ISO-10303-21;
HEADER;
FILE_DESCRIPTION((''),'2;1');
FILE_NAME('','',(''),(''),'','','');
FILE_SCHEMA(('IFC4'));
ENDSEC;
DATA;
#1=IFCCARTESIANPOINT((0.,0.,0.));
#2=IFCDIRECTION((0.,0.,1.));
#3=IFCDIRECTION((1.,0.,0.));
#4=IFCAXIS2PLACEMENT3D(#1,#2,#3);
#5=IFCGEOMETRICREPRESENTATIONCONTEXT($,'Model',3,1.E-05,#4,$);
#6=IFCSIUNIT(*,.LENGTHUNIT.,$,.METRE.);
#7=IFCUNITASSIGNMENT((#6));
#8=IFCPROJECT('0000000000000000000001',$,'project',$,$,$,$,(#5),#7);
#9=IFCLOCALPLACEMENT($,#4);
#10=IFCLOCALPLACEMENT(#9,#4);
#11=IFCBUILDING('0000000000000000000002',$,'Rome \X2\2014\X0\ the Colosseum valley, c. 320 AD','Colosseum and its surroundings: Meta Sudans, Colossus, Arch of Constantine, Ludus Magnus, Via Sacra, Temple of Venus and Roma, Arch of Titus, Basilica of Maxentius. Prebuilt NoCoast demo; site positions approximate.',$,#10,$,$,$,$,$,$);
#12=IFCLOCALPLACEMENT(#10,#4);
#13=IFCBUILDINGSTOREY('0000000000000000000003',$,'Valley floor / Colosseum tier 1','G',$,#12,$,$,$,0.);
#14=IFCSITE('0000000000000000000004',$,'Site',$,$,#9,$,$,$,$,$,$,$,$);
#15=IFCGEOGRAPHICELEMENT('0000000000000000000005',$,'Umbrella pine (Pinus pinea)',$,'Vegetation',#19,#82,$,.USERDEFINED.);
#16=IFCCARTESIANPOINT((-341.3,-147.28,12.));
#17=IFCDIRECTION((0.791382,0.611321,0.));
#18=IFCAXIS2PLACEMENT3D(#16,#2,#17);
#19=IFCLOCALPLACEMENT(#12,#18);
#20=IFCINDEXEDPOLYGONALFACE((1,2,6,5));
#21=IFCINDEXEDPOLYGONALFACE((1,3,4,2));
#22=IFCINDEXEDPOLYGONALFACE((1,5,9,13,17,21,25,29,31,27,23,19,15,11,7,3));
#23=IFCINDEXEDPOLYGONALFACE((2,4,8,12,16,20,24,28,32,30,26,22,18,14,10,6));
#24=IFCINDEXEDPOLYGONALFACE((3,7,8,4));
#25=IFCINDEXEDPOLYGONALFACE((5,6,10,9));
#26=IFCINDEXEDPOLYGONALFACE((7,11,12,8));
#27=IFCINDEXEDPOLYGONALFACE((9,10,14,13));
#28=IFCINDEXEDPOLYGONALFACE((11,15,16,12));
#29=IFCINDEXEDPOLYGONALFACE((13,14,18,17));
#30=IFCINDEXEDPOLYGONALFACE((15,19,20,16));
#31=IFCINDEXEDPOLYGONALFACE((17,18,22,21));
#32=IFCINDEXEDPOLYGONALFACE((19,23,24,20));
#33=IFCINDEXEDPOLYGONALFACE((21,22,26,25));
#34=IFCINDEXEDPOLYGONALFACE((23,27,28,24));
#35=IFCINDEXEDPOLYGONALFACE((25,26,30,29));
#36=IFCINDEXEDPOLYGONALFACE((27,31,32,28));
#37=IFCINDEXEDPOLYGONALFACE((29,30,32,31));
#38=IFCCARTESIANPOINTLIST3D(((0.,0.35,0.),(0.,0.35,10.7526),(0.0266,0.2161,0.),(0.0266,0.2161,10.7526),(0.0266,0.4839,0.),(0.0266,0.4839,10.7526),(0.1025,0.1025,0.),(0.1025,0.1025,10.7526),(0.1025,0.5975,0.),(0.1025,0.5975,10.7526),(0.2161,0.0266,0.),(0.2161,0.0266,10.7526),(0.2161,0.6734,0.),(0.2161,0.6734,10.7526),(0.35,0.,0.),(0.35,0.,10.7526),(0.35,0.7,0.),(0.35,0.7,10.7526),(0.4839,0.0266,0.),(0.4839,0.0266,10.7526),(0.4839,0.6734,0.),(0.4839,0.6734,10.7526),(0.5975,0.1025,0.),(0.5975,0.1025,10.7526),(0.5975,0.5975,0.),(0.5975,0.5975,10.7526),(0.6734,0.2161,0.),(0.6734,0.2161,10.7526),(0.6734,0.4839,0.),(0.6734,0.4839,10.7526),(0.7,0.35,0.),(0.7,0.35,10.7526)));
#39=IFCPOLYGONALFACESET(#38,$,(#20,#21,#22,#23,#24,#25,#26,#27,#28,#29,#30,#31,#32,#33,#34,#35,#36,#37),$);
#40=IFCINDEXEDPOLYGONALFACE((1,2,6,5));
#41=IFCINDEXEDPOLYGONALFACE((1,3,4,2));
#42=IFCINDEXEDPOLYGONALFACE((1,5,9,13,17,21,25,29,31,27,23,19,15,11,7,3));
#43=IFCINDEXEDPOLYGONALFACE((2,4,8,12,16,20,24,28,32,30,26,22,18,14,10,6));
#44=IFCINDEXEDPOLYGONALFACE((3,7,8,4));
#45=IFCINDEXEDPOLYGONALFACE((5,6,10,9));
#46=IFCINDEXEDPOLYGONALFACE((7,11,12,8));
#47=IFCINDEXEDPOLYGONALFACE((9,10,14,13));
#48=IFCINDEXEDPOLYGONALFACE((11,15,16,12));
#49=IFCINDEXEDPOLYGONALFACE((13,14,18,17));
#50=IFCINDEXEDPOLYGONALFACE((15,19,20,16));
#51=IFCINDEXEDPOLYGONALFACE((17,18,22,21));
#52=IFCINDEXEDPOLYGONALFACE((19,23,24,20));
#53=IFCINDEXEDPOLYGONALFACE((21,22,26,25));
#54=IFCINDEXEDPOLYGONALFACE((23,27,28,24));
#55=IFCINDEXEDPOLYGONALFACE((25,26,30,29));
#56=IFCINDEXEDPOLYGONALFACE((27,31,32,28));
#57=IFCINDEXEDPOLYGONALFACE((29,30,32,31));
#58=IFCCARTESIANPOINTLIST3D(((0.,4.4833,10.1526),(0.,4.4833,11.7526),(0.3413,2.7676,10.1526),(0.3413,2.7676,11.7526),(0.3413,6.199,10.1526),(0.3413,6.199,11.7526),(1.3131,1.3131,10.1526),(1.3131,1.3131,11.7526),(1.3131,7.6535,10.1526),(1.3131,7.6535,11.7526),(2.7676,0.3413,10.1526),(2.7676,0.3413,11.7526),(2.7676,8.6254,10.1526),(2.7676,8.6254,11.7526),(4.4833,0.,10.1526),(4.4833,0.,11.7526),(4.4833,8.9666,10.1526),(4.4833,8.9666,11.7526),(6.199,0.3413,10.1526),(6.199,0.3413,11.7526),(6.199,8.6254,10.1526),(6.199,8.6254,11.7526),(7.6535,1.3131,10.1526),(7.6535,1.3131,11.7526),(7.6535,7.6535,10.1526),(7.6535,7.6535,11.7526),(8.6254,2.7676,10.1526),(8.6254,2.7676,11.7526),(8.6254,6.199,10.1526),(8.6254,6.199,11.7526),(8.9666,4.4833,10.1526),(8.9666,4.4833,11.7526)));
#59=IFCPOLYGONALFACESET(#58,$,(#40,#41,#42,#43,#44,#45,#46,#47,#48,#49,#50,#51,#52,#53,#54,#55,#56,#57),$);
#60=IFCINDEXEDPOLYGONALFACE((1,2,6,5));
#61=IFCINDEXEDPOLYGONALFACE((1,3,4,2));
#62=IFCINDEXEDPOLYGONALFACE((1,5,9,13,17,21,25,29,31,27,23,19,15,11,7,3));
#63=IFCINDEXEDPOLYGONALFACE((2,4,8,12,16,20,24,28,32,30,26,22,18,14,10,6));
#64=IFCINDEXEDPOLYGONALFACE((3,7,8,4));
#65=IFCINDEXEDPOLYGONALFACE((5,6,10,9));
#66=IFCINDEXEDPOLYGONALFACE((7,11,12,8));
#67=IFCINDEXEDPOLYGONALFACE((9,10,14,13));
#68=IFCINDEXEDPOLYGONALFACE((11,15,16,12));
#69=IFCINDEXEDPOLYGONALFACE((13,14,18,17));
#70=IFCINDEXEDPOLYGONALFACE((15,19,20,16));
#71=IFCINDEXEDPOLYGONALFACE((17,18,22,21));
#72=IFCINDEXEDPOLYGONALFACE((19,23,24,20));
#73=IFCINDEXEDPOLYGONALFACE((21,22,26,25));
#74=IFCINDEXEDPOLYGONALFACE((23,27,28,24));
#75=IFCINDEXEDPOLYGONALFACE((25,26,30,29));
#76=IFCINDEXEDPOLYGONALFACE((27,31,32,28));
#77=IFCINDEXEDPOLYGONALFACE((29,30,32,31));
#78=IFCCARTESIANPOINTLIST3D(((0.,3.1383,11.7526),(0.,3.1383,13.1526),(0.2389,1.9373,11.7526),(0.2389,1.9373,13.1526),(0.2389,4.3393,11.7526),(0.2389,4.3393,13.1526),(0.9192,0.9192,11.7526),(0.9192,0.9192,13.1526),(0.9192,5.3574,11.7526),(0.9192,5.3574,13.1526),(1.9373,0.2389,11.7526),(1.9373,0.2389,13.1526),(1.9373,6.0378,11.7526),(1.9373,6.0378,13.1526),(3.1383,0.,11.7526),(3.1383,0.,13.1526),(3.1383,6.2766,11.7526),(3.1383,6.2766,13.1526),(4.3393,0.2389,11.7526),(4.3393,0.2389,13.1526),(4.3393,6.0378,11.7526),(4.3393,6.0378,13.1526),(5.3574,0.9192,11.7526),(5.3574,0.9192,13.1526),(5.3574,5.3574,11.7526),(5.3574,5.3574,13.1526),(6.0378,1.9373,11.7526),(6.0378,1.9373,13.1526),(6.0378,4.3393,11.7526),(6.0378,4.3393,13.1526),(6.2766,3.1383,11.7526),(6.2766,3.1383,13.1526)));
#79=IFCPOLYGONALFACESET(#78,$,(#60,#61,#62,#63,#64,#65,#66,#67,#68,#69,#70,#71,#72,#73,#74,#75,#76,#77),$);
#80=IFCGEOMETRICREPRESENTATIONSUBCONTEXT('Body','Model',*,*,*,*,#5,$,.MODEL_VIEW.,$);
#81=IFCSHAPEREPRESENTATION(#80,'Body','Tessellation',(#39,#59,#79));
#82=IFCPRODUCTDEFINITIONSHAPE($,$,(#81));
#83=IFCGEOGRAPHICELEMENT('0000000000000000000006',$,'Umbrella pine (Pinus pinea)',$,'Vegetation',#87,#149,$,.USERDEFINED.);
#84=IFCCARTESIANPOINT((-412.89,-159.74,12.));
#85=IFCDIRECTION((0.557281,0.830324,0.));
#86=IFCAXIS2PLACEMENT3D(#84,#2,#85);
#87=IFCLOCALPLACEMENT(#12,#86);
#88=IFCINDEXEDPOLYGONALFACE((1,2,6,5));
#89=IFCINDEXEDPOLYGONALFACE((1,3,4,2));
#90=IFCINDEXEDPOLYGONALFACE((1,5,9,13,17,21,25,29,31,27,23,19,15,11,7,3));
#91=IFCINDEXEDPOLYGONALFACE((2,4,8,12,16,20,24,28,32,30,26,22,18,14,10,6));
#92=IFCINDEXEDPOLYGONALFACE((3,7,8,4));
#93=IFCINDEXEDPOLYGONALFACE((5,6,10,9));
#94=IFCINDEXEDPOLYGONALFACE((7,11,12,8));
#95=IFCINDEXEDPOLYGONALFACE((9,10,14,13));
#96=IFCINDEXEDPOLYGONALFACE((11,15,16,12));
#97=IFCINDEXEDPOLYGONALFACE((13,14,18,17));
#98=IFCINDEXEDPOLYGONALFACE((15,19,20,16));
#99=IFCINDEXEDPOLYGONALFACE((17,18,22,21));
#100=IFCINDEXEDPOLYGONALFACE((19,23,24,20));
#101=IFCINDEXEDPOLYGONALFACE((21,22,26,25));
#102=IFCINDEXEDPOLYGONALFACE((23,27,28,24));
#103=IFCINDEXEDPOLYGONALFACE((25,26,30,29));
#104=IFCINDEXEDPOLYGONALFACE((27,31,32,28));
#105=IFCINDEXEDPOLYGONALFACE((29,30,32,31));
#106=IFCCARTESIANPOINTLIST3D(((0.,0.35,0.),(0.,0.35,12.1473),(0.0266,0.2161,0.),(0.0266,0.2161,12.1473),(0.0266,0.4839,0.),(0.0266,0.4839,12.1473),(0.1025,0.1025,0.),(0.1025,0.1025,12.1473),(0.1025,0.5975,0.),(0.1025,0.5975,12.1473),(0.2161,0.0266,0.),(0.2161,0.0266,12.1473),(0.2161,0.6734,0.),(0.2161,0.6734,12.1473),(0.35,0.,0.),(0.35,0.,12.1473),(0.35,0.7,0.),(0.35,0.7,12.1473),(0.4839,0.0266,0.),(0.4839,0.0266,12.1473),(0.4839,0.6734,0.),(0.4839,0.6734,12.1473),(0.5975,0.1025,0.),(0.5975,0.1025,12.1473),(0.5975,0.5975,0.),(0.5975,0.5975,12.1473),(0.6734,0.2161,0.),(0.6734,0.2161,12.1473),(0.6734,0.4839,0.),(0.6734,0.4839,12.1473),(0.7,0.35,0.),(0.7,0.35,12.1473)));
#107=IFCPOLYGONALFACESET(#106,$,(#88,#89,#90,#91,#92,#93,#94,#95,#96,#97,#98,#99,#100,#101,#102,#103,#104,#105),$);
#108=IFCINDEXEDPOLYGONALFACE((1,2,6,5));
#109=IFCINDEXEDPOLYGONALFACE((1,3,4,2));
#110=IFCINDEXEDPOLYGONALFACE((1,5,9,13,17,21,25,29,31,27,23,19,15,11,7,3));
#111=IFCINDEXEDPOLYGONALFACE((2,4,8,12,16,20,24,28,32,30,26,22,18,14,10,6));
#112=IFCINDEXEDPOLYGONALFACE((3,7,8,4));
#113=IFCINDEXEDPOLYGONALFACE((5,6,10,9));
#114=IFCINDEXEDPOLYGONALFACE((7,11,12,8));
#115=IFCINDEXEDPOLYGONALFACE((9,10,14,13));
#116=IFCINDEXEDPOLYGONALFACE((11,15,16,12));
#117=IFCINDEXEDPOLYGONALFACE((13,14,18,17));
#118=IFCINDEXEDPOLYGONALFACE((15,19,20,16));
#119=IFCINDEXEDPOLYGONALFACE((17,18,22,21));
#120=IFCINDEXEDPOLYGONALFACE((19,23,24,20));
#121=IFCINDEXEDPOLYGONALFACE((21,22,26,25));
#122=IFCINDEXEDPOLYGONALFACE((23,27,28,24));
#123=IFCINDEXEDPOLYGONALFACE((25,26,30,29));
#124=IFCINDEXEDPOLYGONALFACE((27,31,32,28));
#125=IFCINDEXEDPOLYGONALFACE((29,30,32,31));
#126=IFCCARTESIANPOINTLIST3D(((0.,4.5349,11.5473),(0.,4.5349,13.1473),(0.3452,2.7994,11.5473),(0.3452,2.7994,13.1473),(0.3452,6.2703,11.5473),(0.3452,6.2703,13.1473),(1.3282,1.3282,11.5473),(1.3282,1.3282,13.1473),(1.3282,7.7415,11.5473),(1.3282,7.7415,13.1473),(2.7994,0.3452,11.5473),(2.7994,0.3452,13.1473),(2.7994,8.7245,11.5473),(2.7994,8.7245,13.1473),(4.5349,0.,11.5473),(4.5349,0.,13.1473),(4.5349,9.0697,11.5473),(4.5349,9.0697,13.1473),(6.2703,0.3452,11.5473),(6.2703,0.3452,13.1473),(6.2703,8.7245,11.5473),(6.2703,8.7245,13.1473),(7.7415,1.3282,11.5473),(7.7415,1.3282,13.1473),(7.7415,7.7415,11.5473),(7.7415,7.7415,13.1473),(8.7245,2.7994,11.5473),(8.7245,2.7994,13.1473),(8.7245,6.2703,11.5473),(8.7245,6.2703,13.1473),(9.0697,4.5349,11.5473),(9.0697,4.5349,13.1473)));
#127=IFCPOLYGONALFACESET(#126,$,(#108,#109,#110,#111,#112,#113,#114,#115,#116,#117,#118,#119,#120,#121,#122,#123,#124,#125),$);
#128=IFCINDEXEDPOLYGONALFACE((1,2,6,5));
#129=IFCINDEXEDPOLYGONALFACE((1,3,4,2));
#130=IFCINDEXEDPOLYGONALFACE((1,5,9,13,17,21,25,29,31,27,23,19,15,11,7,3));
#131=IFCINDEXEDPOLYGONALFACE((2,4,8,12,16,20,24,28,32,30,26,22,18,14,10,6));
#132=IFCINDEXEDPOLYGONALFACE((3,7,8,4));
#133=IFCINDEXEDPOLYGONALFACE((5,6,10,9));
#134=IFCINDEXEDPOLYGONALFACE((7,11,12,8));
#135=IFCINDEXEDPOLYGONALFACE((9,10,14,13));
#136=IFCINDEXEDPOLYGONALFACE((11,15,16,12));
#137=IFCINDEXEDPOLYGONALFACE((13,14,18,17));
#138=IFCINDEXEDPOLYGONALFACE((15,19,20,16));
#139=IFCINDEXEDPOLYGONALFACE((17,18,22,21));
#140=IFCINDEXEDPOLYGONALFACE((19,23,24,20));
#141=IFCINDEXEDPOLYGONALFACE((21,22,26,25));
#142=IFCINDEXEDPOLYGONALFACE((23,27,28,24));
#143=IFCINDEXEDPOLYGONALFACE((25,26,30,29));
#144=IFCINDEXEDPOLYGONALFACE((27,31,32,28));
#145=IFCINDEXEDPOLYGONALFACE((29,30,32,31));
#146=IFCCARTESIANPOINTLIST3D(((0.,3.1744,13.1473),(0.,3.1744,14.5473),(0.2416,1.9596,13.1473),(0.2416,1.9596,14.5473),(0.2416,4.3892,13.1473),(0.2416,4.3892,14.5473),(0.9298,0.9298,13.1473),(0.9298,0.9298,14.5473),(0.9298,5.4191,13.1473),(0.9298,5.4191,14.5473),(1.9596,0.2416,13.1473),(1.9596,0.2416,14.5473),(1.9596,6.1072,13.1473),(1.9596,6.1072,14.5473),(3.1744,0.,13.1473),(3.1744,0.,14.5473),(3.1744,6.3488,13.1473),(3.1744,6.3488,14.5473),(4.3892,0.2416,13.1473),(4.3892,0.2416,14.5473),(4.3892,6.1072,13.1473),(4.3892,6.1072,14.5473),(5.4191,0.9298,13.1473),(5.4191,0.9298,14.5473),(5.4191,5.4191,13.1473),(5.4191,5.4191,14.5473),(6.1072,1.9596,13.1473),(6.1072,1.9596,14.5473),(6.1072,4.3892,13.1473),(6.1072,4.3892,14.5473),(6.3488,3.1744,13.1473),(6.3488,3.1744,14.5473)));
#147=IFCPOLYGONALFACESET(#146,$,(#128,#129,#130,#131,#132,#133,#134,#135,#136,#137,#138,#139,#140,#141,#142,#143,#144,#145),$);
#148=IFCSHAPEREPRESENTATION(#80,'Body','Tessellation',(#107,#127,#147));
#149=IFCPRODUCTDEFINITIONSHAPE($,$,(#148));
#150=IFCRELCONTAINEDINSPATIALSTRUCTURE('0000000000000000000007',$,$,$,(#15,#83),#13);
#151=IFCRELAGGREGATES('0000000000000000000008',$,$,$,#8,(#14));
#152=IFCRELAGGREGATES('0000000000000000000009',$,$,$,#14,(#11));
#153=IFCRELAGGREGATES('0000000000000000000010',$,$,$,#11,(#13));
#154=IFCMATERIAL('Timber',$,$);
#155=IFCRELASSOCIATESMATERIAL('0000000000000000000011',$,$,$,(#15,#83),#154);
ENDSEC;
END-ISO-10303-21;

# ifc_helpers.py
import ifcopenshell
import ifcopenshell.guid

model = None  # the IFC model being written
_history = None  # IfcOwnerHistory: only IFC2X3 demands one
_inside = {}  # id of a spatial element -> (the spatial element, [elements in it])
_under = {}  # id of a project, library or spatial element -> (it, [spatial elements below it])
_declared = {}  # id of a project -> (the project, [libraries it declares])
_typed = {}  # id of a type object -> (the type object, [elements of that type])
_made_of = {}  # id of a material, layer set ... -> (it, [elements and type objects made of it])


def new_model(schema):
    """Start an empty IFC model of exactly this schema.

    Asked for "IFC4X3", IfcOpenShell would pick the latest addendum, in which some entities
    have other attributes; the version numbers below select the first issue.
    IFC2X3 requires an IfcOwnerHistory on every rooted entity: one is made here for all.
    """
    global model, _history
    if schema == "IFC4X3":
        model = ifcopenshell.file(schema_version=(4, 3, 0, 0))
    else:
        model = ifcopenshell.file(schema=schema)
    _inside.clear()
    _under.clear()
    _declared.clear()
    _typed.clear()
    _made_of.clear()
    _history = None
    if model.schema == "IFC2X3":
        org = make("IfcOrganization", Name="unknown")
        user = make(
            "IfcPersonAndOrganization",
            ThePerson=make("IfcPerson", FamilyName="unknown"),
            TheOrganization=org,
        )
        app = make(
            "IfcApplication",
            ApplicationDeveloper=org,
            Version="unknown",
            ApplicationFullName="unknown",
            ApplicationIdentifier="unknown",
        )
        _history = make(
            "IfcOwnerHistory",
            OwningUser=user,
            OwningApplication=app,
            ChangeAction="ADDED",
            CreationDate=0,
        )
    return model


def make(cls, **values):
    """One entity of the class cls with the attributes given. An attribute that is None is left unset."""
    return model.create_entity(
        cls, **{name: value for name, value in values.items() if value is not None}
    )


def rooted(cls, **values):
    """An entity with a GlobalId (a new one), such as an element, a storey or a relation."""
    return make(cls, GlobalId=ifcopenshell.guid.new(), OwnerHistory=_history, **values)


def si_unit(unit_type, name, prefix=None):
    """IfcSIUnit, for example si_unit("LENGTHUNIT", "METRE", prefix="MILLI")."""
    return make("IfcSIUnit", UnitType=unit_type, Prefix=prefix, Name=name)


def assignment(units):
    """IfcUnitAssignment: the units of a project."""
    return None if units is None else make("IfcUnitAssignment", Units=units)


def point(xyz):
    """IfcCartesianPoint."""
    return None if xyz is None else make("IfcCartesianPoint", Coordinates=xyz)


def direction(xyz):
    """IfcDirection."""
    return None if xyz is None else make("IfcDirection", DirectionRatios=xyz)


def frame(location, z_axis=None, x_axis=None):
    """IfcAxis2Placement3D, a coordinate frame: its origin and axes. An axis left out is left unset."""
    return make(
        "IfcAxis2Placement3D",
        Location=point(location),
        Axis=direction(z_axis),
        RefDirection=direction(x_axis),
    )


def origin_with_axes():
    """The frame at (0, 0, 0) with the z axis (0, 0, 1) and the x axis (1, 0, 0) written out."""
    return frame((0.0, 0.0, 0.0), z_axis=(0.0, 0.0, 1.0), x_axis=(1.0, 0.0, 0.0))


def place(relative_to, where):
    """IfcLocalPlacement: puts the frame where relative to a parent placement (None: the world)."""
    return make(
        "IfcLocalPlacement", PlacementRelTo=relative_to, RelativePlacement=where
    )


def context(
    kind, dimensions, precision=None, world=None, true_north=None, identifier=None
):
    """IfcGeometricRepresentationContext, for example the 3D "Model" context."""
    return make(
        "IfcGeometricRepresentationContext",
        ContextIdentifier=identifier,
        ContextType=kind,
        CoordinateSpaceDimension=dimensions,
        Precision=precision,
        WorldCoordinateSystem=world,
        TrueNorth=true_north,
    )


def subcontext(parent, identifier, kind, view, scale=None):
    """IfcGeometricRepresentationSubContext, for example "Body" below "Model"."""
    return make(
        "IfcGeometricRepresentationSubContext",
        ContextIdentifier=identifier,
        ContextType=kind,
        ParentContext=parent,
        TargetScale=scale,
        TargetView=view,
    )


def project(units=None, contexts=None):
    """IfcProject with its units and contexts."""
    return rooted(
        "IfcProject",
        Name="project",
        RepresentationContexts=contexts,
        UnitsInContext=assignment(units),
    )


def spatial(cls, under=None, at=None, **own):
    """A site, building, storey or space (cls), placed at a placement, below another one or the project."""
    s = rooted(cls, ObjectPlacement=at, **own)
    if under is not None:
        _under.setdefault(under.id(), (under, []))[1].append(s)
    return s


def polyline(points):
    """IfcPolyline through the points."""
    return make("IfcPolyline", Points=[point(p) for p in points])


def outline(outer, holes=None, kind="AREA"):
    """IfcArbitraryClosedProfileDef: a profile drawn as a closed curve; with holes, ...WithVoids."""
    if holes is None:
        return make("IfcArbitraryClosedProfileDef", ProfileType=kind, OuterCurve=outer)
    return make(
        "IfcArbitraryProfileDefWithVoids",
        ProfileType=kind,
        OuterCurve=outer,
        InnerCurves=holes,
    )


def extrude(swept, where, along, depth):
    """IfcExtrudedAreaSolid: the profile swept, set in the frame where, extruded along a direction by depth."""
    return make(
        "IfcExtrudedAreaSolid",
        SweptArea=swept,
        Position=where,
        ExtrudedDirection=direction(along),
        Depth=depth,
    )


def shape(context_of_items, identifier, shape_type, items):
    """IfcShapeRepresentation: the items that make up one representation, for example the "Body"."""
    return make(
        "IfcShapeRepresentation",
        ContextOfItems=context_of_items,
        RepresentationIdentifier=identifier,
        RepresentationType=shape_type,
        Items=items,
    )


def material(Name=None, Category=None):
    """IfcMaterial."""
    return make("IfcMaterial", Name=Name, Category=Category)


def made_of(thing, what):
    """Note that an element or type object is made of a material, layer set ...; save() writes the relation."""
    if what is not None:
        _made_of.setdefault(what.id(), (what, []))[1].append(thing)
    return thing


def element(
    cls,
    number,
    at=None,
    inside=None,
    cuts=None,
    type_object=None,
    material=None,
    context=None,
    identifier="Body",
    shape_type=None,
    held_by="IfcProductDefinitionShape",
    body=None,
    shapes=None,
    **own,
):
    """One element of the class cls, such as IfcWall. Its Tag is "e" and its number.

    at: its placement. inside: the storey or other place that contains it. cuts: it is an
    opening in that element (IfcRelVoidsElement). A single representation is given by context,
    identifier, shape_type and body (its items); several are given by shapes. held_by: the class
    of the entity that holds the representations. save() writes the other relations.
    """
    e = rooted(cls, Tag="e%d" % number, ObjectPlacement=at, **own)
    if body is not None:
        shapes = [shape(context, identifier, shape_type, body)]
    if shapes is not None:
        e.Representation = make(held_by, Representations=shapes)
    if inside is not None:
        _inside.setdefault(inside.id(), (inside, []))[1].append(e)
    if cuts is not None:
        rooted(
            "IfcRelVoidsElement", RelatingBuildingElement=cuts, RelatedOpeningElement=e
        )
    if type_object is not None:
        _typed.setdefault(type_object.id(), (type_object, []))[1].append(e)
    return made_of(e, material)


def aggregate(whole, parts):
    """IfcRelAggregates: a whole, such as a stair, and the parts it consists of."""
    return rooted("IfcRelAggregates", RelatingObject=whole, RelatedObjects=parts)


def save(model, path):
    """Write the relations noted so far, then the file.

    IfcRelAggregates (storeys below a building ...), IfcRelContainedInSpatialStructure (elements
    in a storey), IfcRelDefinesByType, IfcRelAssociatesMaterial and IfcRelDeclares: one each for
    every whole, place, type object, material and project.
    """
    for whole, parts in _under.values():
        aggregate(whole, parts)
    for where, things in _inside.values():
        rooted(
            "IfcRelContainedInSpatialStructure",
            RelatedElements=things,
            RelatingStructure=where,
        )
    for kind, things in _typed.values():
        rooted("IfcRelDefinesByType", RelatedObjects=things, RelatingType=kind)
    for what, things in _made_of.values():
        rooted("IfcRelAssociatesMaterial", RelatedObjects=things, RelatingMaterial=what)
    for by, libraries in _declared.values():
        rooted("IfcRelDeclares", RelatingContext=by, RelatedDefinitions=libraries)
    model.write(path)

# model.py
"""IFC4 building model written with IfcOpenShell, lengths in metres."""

from ifc_helpers import new_model, si_unit, frame, origin_with_axes, place, context, subcontext, project, spatial, polyline, outline, extrude, material, element, save


model = new_model("IFC4")

# Units and contexts
model_context = context("Model", 3, precision=1e-05, world=origin_with_axes())
body_context = subcontext(model_context, "Body", "Model", "MODEL_VIEW")
ifc_project = project(units=[si_unit("LENGTHUNIT", "METRE")], contexts=[model_context])

# Site, building, storey
site_placement = place(None, origin_with_axes())
site = spatial("IfcSite", under=ifc_project, at=site_placement, Name="Site")
building_placement = place(site_placement, origin_with_axes())
building = spatial("IfcBuilding", under=site, at=building_placement, Name="Rome — the Colosseum valley, c. 320 AD", Description="Colosseum and its surroundings: Meta Sudans, Colossus, Arch of Constantine, Ludus Magnus, Via Sacra, Temple of Venus and Roma, Arch of Titus, Basilica of Maxentius. Prebuilt NoCoast demo; site positions approximate.")
storey_placement = place(building_placement, origin_with_axes())
storey = spatial("IfcBuildingStorey", under=building, at=storey_placement, Name="Valley floor / Colosseum tier 1", Description="G", Elevation=0.0)

# Shared definitions
ifc_material_1 = material(Name="Timber")

# Geographic elements
geographic_element_1_placement = place(storey_placement, frame((-341.3, -147.28, 12.0), z_axis=(0.0, 0.0, 1.0), x_axis=(0.791382, 0.611321, 0.0)))
element("IfcGeographicElement", 1, at=geographic_element_1_placement, inside=storey, material=ifc_material_1, Name="Umbrella pine (Pinus pinea)", ObjectType="Vegetation", PredefinedType="USERDEFINED", context=body_context, shape_type="SweptSolid", body=[
    extrude(outline(polyline([(0.7, 0.35), (0.6734, 0.4839), (0.5975, 0.5975), (0.4839, 0.6734), (0.35, 0.7), (0.2161, 0.6734), (0.1025, 0.5975), (0.0266, 0.4839), (0.0, 0.35), (0.0266, 0.2161), (0.1025, 0.1025), (0.2161, 0.0266), (0.35, 0.0), (0.4839, 0.0266), (0.5975, 0.1025), (0.6734, 0.2161), (0.7, 0.35)])), origin_with_axes(), (0.0, 0.0, 1.0), 10.7526),
    extrude(outline(polyline([(8.9666, 4.4833), (8.6254, 6.199), (7.6535, 7.6535), (6.199, 8.6254), (4.4833, 8.9666), (2.7676, 8.6254), (1.3131, 7.6535), (0.3413, 6.199), (0.0, 4.4833), (0.3413, 2.7676), (1.3131, 1.3131), (2.7676, 0.3413), (4.4833, 0.0), (6.199, 0.3413), (7.6535, 1.3131), (8.6254, 2.7676), (8.9666, 4.4833)])), frame((0.0, 0.0, 10.1526), z_axis=(0.0, 0.0, 1.0), x_axis=(1.0, 0.0, 0.0)), (0.0, 0.0, 1.0), 1.6),
    extrude(outline(polyline([(6.2766, 3.1383), (6.0378, 4.3393), (5.3574, 5.3574), (4.3393, 6.0378), (3.1383, 6.2766), (1.9373, 6.0378), (0.9192, 5.3574), (0.2389, 4.3393), (0.0, 3.1383), (0.2389, 1.9373), (0.9192, 0.9192), (1.9373, 0.2389), (3.1383, 0.0), (4.3393, 0.2389), (5.3574, 0.9192), (6.0378, 1.9373), (6.2766, 3.1383)])), frame((0.0, 0.0, 11.7526), z_axis=(0.0, 0.0, 1.0), x_axis=(1.0, 0.0, 0.0)), (0.0, 0.0, 1.0), 1.4),
])
geographic_element_2_placement = place(storey_placement, frame((-412.89, -159.74, 12.0), z_axis=(0.0, 0.0, 1.0), x_axis=(0.557281, 0.830324, 0.0)))
element("IfcGeographicElement", 2, at=geographic_element_2_placement, inside=storey, material=ifc_material_1, Name="Umbrella pine (Pinus pinea)", ObjectType="Vegetation", PredefinedType="USERDEFINED", context=body_context, shape_type="SweptSolid", body=[
    extrude(outline(polyline([(0.7, 0.35), (0.6734, 0.4839), (0.5975, 0.5975), (0.4839, 0.6734), (0.35, 0.7), (0.2161, 0.6734), (0.1025, 0.5975), (0.0266, 0.4839), (0.0, 0.35), (0.0266, 0.2161), (0.1025, 0.1025), (0.2161, 0.0266), (0.35, 0.0), (0.4839, 0.0266), (0.5975, 0.1025), (0.6734, 0.2161), (0.7, 0.35)])), origin_with_axes(), (0.0, 0.0, 1.0), 12.1473),
    extrude(outline(polyline([(9.0697, 4.5349), (8.7245, 6.2703), (7.7415, 7.7415), (6.2703, 8.7245), (4.5349, 9.0697), (2.7994, 8.7245), (1.3282, 7.7415), (0.3452, 6.2703), (0.0, 4.5349), (0.3452, 2.7994), (1.3282, 1.3282), (2.7994, 0.3452), (4.5349, 0.0), (6.2703, 0.3452), (7.7415, 1.3282), (8.7245, 2.7994), (9.0697, 4.5349)])), frame((0.0, 0.0, 11.5473), z_axis=(0.0, 0.0, 1.0), x_axis=(1.0, 0.0, 0.0)), (0.0, 0.0, 1.0), 1.6),
    extrude(outline(polyline([(6.3488, 3.1744), (6.1072, 4.3892), (5.4191, 5.4191), (4.3892, 6.1072), (3.1744, 6.3488), (1.9596, 6.1072), (0.9298, 5.4191), (0.2416, 4.3892), (0.0, 3.1744), (0.2416, 1.9596), (0.9298, 0.9298), (1.9596, 0.2416), (3.1744, 0.0), (4.3892, 0.2416), (5.4191, 0.9298), (6.1072, 1.9596), (6.3488, 3.1744)])), frame((0.0, 0.0, 13.1473), z_axis=(0.0, 0.0, 1.0), x_axis=(1.0, 0.0, 0.0)), (0.0, 0.0, 1.0), 1.4),
])

save(model, "model.ifc")
